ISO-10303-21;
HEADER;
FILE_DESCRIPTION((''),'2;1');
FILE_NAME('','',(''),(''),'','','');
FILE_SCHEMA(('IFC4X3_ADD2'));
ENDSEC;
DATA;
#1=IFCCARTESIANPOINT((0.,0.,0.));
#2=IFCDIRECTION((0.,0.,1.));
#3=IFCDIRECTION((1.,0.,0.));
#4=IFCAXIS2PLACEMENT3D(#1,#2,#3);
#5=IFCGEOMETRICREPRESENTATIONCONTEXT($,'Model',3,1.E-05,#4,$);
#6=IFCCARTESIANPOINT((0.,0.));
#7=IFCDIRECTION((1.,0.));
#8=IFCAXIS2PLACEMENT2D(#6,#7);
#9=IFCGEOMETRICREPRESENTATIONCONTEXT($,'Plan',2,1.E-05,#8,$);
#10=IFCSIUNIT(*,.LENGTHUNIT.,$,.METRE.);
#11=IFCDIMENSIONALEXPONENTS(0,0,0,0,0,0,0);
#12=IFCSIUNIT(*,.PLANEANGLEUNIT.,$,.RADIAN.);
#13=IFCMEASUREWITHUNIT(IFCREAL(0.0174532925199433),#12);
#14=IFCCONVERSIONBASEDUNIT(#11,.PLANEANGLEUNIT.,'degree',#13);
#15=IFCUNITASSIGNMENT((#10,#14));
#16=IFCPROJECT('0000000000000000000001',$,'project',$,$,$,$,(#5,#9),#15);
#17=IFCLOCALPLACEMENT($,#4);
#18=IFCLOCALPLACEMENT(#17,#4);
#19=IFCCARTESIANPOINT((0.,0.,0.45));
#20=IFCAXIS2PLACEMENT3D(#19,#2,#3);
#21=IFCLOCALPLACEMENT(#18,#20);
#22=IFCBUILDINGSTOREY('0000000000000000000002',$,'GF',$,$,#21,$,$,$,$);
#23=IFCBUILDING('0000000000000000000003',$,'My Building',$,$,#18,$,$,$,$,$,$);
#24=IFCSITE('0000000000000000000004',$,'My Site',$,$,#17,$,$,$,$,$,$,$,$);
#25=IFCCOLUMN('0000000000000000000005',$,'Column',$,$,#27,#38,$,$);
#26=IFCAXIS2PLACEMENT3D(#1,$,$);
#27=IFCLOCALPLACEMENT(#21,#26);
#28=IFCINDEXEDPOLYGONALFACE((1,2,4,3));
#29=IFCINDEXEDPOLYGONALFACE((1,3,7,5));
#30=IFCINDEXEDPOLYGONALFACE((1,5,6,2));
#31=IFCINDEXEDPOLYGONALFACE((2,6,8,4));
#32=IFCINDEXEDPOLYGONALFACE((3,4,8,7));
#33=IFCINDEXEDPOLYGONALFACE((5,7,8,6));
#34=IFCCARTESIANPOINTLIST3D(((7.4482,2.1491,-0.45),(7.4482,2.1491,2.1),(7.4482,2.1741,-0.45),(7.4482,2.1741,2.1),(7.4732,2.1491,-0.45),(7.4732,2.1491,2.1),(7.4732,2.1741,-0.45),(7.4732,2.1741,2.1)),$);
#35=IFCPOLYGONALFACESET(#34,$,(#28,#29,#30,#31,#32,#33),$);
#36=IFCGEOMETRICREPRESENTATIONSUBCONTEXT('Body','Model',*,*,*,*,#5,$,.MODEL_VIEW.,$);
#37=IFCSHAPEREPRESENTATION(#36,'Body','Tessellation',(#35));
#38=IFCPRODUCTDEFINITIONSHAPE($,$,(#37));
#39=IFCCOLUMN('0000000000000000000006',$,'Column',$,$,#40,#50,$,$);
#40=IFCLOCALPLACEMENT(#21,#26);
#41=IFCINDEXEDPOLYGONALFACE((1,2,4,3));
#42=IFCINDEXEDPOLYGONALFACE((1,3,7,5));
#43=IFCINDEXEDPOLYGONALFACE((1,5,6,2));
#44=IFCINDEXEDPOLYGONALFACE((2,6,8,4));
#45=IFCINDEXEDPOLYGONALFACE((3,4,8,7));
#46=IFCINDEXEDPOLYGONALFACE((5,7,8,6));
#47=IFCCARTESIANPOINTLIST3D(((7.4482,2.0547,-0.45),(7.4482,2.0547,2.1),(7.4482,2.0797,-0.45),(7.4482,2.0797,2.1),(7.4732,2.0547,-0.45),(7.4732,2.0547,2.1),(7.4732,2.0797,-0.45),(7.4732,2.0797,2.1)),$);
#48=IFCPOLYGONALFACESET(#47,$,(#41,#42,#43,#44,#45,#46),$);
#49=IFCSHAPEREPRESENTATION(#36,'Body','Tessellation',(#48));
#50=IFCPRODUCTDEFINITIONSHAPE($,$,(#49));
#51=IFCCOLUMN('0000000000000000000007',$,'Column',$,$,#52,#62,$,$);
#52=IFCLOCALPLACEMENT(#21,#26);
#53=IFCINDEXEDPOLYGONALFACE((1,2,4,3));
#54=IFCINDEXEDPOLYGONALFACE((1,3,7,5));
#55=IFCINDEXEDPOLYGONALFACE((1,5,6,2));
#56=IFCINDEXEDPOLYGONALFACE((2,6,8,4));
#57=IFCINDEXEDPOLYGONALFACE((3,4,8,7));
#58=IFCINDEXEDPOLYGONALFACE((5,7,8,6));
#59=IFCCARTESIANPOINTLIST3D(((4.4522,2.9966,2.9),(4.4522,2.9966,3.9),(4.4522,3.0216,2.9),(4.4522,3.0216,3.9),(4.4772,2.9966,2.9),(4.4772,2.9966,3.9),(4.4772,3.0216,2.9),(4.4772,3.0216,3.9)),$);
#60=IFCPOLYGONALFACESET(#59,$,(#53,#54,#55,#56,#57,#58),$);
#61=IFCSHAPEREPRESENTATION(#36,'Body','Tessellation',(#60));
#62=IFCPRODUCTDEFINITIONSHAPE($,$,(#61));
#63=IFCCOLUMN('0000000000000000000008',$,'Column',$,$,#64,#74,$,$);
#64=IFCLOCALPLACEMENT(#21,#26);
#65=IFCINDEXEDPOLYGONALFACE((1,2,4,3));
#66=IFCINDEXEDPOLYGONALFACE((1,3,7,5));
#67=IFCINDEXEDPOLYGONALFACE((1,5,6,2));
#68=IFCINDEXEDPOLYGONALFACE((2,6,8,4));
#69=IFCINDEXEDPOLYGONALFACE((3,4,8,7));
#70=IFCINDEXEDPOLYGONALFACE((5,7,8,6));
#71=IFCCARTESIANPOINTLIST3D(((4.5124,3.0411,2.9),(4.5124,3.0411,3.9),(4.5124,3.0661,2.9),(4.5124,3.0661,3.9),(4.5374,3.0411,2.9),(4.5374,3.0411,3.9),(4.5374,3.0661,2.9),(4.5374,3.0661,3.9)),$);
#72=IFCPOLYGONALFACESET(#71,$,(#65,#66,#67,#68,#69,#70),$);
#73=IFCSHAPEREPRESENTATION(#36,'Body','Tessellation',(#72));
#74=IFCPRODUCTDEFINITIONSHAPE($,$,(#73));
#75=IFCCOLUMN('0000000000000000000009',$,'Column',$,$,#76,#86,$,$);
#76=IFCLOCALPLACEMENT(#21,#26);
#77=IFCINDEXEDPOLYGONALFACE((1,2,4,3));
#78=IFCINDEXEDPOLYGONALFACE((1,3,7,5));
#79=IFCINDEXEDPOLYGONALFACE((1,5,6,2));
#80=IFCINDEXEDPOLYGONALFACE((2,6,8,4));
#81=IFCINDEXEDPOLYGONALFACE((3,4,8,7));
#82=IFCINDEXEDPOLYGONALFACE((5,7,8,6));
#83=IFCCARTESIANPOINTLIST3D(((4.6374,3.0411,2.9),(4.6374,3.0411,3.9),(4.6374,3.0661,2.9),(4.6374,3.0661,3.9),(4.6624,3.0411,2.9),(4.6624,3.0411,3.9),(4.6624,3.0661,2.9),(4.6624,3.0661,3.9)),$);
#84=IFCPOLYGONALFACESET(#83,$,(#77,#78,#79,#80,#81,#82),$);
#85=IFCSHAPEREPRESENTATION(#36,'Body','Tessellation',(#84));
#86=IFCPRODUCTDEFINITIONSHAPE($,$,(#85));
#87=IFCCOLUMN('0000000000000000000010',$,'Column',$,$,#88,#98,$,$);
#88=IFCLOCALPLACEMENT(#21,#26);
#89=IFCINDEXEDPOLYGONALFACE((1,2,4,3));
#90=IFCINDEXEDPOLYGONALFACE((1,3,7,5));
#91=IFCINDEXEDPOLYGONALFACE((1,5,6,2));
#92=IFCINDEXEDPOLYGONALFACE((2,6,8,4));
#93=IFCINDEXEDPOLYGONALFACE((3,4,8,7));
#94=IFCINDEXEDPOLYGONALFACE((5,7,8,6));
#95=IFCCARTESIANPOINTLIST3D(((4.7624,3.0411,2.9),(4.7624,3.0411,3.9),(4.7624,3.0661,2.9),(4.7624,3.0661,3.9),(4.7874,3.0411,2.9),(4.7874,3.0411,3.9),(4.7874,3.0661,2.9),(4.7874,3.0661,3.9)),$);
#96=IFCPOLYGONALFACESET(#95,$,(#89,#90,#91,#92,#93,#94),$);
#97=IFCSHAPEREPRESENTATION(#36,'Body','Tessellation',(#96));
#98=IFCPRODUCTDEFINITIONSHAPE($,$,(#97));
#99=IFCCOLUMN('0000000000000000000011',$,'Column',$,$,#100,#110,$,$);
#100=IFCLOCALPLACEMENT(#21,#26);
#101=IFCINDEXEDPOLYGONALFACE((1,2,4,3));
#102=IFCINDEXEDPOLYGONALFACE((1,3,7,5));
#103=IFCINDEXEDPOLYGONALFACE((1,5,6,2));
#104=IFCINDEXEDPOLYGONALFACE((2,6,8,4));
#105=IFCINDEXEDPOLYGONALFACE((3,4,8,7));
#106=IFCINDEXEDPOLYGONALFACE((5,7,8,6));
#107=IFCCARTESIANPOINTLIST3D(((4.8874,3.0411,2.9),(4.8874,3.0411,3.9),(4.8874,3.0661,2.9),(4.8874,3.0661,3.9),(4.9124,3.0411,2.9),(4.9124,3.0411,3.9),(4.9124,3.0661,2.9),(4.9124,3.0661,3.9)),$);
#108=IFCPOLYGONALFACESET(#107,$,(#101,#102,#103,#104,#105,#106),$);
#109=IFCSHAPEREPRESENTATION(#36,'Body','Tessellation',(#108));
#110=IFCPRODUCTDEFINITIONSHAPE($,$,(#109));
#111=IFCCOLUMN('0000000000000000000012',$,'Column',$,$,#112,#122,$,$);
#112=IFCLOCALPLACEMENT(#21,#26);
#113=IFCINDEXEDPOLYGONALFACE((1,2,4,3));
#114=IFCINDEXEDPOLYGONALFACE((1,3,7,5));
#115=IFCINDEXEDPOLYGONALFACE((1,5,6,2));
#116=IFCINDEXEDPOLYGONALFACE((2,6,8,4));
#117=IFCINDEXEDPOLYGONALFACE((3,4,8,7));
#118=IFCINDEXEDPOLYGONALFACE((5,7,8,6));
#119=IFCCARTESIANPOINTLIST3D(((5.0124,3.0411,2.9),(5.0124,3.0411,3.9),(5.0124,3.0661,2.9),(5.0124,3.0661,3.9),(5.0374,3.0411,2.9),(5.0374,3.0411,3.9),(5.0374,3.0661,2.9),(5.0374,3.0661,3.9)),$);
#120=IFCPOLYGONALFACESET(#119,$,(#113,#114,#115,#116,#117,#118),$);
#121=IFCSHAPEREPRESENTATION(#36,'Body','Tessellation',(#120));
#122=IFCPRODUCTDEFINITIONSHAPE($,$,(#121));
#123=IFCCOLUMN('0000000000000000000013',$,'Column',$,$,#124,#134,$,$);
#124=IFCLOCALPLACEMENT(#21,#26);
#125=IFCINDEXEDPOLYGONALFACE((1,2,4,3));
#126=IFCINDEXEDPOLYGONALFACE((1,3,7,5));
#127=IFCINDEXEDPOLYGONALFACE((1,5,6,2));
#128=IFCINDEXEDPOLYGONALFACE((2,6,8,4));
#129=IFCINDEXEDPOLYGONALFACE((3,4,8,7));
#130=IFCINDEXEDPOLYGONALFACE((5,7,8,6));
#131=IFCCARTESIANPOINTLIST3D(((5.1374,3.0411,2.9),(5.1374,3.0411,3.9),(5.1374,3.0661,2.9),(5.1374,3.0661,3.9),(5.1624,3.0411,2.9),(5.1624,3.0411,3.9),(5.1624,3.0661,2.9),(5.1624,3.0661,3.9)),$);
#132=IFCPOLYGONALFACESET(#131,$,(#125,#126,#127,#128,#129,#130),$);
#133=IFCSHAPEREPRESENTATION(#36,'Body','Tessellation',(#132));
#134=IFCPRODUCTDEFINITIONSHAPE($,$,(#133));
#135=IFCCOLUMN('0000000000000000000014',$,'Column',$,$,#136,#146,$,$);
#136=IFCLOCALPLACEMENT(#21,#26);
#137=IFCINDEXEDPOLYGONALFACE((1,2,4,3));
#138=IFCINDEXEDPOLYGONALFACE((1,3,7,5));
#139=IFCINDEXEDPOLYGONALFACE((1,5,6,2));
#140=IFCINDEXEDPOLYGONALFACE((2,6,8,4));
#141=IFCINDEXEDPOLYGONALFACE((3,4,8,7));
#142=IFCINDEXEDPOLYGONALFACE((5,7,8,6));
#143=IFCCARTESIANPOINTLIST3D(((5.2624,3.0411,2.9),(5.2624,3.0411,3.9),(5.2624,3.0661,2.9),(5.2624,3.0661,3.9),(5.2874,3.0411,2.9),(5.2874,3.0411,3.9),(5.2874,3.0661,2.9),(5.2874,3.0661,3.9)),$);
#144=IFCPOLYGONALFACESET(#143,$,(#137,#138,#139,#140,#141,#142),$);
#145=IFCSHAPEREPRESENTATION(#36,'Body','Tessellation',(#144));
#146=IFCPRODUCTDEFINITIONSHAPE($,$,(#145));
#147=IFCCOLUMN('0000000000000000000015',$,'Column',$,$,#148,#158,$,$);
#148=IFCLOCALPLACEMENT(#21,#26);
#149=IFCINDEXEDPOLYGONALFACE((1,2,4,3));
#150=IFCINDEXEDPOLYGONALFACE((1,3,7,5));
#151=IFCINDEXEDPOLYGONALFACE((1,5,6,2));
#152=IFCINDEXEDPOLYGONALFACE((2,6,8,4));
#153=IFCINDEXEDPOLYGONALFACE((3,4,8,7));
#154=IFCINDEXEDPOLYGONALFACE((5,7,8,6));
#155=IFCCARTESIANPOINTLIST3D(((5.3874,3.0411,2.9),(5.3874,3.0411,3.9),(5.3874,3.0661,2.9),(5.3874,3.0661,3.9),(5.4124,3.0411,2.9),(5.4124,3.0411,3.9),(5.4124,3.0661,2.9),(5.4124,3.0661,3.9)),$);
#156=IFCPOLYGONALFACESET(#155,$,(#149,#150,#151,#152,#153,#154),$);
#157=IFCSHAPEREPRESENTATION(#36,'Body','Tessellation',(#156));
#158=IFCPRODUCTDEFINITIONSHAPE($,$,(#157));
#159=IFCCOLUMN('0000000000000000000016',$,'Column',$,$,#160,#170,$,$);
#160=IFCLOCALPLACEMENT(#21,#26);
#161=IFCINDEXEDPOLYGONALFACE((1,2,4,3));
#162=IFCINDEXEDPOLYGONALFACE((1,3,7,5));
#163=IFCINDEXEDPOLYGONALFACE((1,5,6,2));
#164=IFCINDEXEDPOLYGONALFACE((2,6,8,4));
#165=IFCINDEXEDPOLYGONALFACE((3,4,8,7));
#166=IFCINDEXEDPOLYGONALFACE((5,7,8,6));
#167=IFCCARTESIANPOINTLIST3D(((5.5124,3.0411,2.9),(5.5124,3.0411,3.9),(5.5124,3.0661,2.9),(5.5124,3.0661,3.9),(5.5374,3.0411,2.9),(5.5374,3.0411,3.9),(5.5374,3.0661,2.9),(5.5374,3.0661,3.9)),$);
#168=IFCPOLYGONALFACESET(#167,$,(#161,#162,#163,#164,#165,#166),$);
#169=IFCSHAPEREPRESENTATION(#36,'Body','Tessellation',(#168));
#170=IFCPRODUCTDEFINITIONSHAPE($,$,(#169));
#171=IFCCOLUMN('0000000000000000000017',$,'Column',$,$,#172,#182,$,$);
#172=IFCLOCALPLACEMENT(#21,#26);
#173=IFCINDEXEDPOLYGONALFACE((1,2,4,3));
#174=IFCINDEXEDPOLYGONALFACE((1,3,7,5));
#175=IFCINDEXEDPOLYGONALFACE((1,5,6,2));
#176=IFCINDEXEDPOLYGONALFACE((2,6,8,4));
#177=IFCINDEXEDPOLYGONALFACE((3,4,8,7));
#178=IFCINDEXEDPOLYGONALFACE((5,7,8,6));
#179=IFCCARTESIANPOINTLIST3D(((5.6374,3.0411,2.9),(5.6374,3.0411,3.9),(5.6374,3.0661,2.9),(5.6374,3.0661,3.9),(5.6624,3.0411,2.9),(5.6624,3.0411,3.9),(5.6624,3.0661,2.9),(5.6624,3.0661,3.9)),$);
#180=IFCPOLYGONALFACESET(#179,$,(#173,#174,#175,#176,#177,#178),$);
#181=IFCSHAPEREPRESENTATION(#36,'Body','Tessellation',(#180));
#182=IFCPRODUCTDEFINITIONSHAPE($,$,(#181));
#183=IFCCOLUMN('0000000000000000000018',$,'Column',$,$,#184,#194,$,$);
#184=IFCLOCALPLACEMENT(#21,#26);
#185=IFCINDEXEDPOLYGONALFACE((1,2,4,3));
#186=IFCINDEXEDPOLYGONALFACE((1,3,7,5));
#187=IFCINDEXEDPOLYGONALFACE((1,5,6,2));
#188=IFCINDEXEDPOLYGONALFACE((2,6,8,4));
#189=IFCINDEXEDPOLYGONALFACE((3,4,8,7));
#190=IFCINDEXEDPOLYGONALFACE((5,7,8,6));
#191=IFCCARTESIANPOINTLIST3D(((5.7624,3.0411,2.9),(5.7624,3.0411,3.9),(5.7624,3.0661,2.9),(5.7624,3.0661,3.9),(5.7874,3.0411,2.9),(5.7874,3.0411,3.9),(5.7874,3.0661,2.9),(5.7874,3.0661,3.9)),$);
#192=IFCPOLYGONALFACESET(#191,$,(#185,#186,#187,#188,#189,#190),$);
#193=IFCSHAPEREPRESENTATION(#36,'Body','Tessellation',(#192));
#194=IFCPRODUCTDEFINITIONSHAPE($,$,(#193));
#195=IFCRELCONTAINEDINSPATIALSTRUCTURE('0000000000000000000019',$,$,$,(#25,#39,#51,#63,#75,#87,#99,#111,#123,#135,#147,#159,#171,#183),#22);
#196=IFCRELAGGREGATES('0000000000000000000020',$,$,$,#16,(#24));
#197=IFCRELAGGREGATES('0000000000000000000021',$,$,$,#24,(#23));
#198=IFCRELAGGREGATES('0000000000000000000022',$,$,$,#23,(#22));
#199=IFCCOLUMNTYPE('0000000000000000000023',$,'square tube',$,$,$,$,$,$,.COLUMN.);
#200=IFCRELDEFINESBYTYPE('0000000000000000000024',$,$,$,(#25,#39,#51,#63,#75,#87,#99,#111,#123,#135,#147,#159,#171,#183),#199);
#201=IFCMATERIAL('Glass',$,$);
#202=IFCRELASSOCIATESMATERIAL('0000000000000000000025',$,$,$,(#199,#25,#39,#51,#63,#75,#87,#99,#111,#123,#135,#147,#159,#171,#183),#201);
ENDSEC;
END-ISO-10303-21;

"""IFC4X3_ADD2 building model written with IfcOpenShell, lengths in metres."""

from ifc_helpers import new_model, entity, si_unit, converted_unit, frame, origin_with_axes, origin_2d_with_axis, place, context, subcontext, project, spatial, rectangle, extrude, material, material_profile, profile_set, profile_usage, type_object, element, save


model = new_model("IFC4X3_ADD2")

# Units and contexts
model_context = context("Model", 3, precision=1e-05, world=origin_with_axes())
plan_context = context("Plan", 2, precision=1e-05, world=origin_2d_with_axis())
body_context_1 = subcontext(model_context, "Body", "Model", "MODEL_VIEW")
ifc_project = project(units=[si_unit("LENGTHUNIT", "METRE"), converted_unit("PLANEANGLEUNIT", "degree", entity("IfcReal", 0.0174532925199433), si_unit("PLANEANGLEUNIT", "RADIAN"), dimensions=[0, 0, 0, 0, 0, 0, 0])], contexts=[model_context, plan_context])

# Site, building, storey
site_placement = place(None, origin_with_axes())
site = spatial("IfcSite", under=ifc_project, at=site_placement, Name="My Site")
building_placement = place(site_placement, origin_with_axes())
building = spatial("IfcBuilding", under=site, at=building_placement, Name="My Building")
storey_placement = place(building_placement, frame((0.0, 0.0, 0.45), z_axis=(0.0, 0.0, 1.0), x_axis=(1.0, 0.0, 0.0)))
storey = spatial("IfcBuildingStorey", under=building, at=storey_placement, Name="GF")

# Columns
ifc_material_1 = material(Name="Glass")
ifc_material_profile = material_profile(ifc_material_1, rectangle(XDim=0.025, YDim=0.025))
ifc_profile_set = profile_set([ifc_material_profile])
column_type = type_object("IfcColumnType", Name="square tube", PredefinedType="COLUMN", material=ifc_profile_set)
ifc_profile_usage_1 = profile_usage(ifc_profile_set, cardinal=5)
column_1_placement = place(storey_placement, frame((7.4607, 2.1616, -0.45), z_axis=(0.0, 0.0, 1.0), x_axis=(0.0, -1.0, 0.0)))
element("IfcColumn", 1, at=column_1_placement, inside=storey, type_object=column_type, material=ifc_profile_usage_1, Name="Column", context=body_context_1, shape_type="SweptSolid", body=[
    extrude(rectangle(XDim=0.025, YDim=0.025), origin_with_axes(), (0.0, 0.0, 1.0), 2.55),
])
ifc_profile_usage_2 = profile_usage(ifc_profile_set, cardinal=5)
column_2_placement = place(storey_placement, frame((7.4607, 2.0672, -0.45), z_axis=(0.0, 0.0, 1.0), x_axis=(0.0, -1.0, 0.0)))
element("IfcColumn", 2, at=column_2_placement, inside=storey, type_object=column_type, material=ifc_profile_usage_2, Name="Column", context=body_context_1, shape_type="SweptSolid", body=[
    extrude(rectangle(XDim=0.025, YDim=0.025), origin_with_axes(), (0.0, 0.0, 1.0), 2.55),
])
ifc_profile_usage_3 = profile_usage(ifc_profile_set, cardinal=5)
column_3_placement = place(storey_placement, frame((4.4647, 3.0091, 2.9), z_axis=(0.0, 0.0, 1.0), x_axis=(0.0, -1.0, 0.0)))
element("IfcColumn", 3, at=column_3_placement, inside=storey, type_object=column_type, material=ifc_profile_usage_3, Name="Column", context=body_context_1, shape_type="SweptSolid", body=[
    extrude(rectangle(XDim=0.025, YDim=0.025), origin_with_axes(), (0.0, 0.0, 1.0), 1.0),
])
ifc_profile_usage_4 = profile_usage(ifc_profile_set, cardinal=5)
column_4_placement = place(storey_placement, frame((4.5249, 3.0536, 2.9), z_axis=(0.0, 0.0, 1.0), x_axis=(1.0, 0.0, 0.0)))
element("IfcColumn", 4, at=column_4_placement, inside=storey, type_object=column_type, material=ifc_profile_usage_4, Name="Column", context=body_context_1, shape_type="SweptSolid", body=[
    extrude(rectangle(XDim=0.025, YDim=0.025), origin_with_axes(), (0.0, 0.0, 1.0), 1.0),
])
ifc_profile_usage_5 = profile_usage(ifc_profile_set, cardinal=5)
column_5_placement = place(storey_placement, frame((4.6499, 3.0536, 2.9), z_axis=(0.0, 0.0, 1.0), x_axis=(1.0, 0.0, 0.0)))
element("IfcColumn", 5, at=column_5_placement, inside=storey, type_object=column_type, material=ifc_profile_usage_5, Name="Column", context=body_context_1, shape_type="SweptSolid", body=[
    extrude(rectangle(XDim=0.025, YDim=0.025), origin_with_axes(), (0.0, 0.0, 1.0), 1.0),
])
ifc_profile_usage_6 = profile_usage(ifc_profile_set, cardinal=5)
column_6_placement = place(storey_placement, frame((4.7749, 3.0536, 2.9), z_axis=(0.0, 0.0, 1.0), x_axis=(1.0, 0.0, 0.0)))
element("IfcColumn", 6, at=column_6_placement, inside=storey, type_object=column_type, material=ifc_profile_usage_6, Name="Column", context=body_context_1, shape_type="SweptSolid", body=[
    extrude(rectangle(XDim=0.025, YDim=0.025), origin_with_axes(), (0.0, 0.0, 1.0), 1.0),
])
ifc_profile_usage_7 = profile_usage(ifc_profile_set, cardinal=5)
column_7_placement = place(storey_placement, frame((4.8999, 3.0536, 2.9), z_axis=(0.0, 0.0, 1.0), x_axis=(1.0, 0.0, 0.0)))
element("IfcColumn", 7, at=column_7_placement, inside=storey, type_object=column_type, material=ifc_profile_usage_7, Name="Column", context=body_context_1, shape_type="SweptSolid", body=[
    extrude(rectangle(XDim=0.025, YDim=0.025), origin_with_axes(), (0.0, 0.0, 1.0), 1.0),
])
ifc_profile_usage_8 = profile_usage(ifc_profile_set, cardinal=5)
column_8_placement = place(storey_placement, frame((5.0249, 3.0536, 2.9), z_axis=(0.0, 0.0, 1.0), x_axis=(1.0, 0.0, 0.0)))
element("IfcColumn", 8, at=column_8_placement, inside=storey, type_object=column_type, material=ifc_profile_usage_8, Name="Column", context=body_context_1, shape_type="SweptSolid", body=[
    extrude(rectangle(XDim=0.025, YDim=0.025), origin_with_axes(), (0.0, 0.0, 1.0), 1.0),
])
ifc_profile_usage_9 = profile_usage(ifc_profile_set, cardinal=5)
column_9_placement = place(storey_placement, frame((5.1499, 3.0536, 2.9), z_axis=(0.0, 0.0, 1.0), x_axis=(1.0, 0.0, 0.0)))
element("IfcColumn", 9, at=column_9_placement, inside=storey, type_object=column_type, material=ifc_profile_usage_9, Name="Column", context=body_context_1, shape_type="SweptSolid", body=[
    extrude(rectangle(XDim=0.025, YDim=0.025), origin_with_axes(), (0.0, 0.0, 1.0), 1.0),
])
ifc_profile_usage_10 = profile_usage(ifc_profile_set, cardinal=5)
column_10_placement = place(storey_placement, frame((5.2749, 3.0536, 2.9), z_axis=(0.0, 0.0, 1.0), x_axis=(1.0, 0.0, 0.0)))
element("IfcColumn", 10, at=column_10_placement, inside=storey, type_object=column_type, material=ifc_profile_usage_10, Name="Column", context=body_context_1, shape_type="SweptSolid", body=[
    extrude(rectangle(XDim=0.025, YDim=0.025), origin_with_axes(), (0.0, 0.0, 1.0), 1.0),
])
ifc_profile_usage_11 = profile_usage(ifc_profile_set, cardinal=5)
column_11_placement = place(storey_placement, frame((5.3999, 3.0536, 2.9), z_axis=(0.0, 0.0, 1.0), x_axis=(1.0, 0.0, 0.0)))
element("IfcColumn", 11, at=column_11_placement, inside=storey, type_object=column_type, material=ifc_profile_usage_11, Name="Column", context=body_context_1, shape_type="SweptSolid", body=[
    extrude(rectangle(XDim=0.025, YDim=0.025), origin_with_axes(), (0.0, 0.0, 1.0), 1.0),
])
ifc_profile_usage_12 = profile_usage(ifc_profile_set, cardinal=5)
column_12_placement = place(storey_placement, frame((5.5249, 3.0536, 2.9), z_axis=(0.0, 0.0, 1.0), x_axis=(1.0, 0.0, 0.0)))
element("IfcColumn", 12, at=column_12_placement, inside=storey, type_object=column_type, material=ifc_profile_usage_12, Name="Column", context=body_context_1, shape_type="SweptSolid", body=[
    extrude(rectangle(XDim=0.025, YDim=0.025), origin_with_axes(), (0.0, 0.0, 1.0), 1.0),
])
ifc_profile_usage_13 = profile_usage(ifc_profile_set, cardinal=5)
column_13_placement = place(storey_placement, frame((5.6499, 3.0536, 2.9), z_axis=(0.0, 0.0, 1.0), x_axis=(1.0, 0.0, 0.0)))
element("IfcColumn", 13, at=column_13_placement, inside=storey, type_object=column_type, material=ifc_profile_usage_13, Name="Column", context=body_context_1, shape_type="SweptSolid", body=[
    extrude(rectangle(XDim=0.025, YDim=0.025), origin_with_axes(), (0.0, 0.0, 1.0), 1.0),
])
ifc_profile_usage_14 = profile_usage(ifc_profile_set, cardinal=5)
column_14_placement = place(storey_placement, frame((5.7749, 3.0536, 2.9), z_axis=(0.0, 0.0, 1.0), x_axis=(1.0, 0.0, 0.0)))
element("IfcColumn", 14, at=column_14_placement, inside=storey, type_object=column_type, material=ifc_profile_usage_14, Name="Column", context=body_context_1, shape_type="SweptSolid", body=[
    extrude(rectangle(XDim=0.025, YDim=0.025), origin_with_axes(), (0.0, 0.0, 1.0), 1.0),
])

save(model, "model.ifc")
